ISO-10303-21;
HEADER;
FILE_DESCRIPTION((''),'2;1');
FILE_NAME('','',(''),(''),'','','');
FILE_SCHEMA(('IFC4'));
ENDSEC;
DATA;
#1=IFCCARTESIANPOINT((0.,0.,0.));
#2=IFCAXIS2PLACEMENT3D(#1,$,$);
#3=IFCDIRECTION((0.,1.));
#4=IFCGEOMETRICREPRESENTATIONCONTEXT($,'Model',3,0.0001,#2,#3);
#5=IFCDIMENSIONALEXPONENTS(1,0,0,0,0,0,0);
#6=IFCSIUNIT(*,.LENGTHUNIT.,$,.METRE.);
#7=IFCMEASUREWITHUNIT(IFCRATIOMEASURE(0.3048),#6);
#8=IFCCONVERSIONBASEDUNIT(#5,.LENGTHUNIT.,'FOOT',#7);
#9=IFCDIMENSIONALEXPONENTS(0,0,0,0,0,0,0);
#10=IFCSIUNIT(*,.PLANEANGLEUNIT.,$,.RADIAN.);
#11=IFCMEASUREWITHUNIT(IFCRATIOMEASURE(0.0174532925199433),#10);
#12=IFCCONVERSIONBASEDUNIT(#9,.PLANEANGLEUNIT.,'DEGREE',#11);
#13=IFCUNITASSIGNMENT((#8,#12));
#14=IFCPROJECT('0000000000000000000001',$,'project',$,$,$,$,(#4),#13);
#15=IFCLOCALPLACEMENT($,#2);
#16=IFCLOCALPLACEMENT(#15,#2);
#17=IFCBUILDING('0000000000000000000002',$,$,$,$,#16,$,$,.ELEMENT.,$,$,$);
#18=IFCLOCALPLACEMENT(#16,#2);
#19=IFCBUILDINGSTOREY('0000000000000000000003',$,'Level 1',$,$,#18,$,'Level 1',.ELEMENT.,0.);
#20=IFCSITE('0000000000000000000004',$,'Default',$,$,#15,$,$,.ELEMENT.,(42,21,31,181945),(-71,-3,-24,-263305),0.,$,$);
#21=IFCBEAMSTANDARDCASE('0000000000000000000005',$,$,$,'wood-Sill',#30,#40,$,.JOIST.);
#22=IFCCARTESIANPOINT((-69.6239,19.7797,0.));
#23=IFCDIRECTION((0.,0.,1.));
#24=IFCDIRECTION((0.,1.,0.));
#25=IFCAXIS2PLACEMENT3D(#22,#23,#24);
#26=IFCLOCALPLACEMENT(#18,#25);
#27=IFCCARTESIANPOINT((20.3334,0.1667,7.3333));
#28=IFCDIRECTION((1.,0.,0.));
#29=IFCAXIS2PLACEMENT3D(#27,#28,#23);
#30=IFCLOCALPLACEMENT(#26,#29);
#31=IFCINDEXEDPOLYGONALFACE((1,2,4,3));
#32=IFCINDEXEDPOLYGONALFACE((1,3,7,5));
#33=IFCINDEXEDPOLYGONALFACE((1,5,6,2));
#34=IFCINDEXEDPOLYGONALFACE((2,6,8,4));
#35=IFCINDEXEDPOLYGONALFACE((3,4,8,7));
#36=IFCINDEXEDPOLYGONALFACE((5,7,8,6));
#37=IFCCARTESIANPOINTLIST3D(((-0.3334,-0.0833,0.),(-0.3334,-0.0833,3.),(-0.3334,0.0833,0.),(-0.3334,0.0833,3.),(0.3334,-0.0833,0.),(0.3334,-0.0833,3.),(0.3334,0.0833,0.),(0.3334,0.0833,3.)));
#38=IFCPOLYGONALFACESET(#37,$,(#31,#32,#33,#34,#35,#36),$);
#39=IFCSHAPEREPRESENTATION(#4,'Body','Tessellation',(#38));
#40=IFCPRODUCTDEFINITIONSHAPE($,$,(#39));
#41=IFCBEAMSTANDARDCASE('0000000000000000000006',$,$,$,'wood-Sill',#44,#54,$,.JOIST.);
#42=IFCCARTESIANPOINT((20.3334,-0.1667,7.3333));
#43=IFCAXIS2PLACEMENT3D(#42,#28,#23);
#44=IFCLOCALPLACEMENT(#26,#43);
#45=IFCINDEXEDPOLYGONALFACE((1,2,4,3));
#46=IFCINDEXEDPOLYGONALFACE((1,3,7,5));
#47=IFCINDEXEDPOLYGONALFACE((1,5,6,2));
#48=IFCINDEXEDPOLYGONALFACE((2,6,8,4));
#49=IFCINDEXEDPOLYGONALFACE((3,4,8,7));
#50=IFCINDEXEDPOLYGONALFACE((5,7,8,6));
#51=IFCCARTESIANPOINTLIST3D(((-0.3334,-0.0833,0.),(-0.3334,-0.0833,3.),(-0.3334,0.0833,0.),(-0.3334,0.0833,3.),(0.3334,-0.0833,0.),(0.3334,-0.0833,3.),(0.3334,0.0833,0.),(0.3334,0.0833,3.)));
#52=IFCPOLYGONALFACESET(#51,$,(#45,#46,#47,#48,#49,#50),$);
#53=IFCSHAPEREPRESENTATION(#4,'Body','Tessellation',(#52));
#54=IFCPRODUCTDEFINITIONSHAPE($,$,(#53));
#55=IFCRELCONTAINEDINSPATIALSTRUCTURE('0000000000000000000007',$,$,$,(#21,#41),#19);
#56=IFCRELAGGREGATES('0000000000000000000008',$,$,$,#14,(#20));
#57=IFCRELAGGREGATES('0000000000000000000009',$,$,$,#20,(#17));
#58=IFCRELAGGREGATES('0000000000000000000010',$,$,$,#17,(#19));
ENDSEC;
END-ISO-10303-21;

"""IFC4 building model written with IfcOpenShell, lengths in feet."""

from ifc_helpers import new_model, entity, si_unit, converted_unit, direction, frame, origin, origin_with_axes, place, context, project, spatial, rectangle, extrude, element, save


model = new_model("IFC4")

# Units and contexts
model_context = context("Model", 3, precision=0.0001, world=origin(), true_north=direction((0.0, 1.0)))
ifc_project = project(units=[converted_unit("LENGTHUNIT", "FOOT", entity("IfcRatioMeasure", 0.3048), si_unit("LENGTHUNIT", "METRE"), dimensions=[1, 0, 0, 0, 0, 0, 0]), converted_unit("PLANEANGLEUNIT", "DEGREE", entity("IfcRatioMeasure", 0.0174532925199433), si_unit("PLANEANGLEUNIT", "RADIAN"), dimensions=[0, 0, 0, 0, 0, 0, 0])], contexts=[model_context])

# Site, building, storey
site_placement = place(None, origin())
site = spatial("IfcSite", under=ifc_project, at=site_placement, Name="Default", CompositionType="ELEMENT", RefLatitude=(42, 21, 31, 181945), RefLongitude=(-71, -3, -24, -263305), RefElevation=0.0)
building_placement = place(site_placement, origin())
building = spatial("IfcBuilding", under=site, at=building_placement, CompositionType="ELEMENT")
storey_placement = place(building_placement, origin())
storey = spatial("IfcBuildingStorey", under=building, at=storey_placement, Name="Level 1", LongName="Level 1", CompositionType="ELEMENT", Elevation=0.0)

# Shared definitions
placement_1 = place(storey_placement, frame((-69.6239, 19.7797, 0.0), z_axis=(0.0, 0.0, 1.0), x_axis=(0.0, 1.0, 0.0)))

# Beams
for number, where, z_axis, x_axis in (
    (1, (20.3334, 0.1667, 7.3333), (1.0, 0.0, 0.0), (0.0, 0.0, 1.0)),
    (2, (20.3334, -0.1667, 7.3333), (1.0, 0.0, 0.0), (0.0, 0.0, 1.0)),
):
    element("IfcBeamStandardCase", number, at=place(placement_1, frame(where, z_axis=z_axis, x_axis=x_axis)), inside=storey, ObjectType="wood-Sill", PredefinedType="JOIST", context=model_context, shape_type="SweptSolid", body=[
        extrude(rectangle(XDim=0.6667, YDim=0.1667), origin_with_axes(), (0.0, 0.0, 1.0), 3.0),
    ])

save(model, "model.ifc")
